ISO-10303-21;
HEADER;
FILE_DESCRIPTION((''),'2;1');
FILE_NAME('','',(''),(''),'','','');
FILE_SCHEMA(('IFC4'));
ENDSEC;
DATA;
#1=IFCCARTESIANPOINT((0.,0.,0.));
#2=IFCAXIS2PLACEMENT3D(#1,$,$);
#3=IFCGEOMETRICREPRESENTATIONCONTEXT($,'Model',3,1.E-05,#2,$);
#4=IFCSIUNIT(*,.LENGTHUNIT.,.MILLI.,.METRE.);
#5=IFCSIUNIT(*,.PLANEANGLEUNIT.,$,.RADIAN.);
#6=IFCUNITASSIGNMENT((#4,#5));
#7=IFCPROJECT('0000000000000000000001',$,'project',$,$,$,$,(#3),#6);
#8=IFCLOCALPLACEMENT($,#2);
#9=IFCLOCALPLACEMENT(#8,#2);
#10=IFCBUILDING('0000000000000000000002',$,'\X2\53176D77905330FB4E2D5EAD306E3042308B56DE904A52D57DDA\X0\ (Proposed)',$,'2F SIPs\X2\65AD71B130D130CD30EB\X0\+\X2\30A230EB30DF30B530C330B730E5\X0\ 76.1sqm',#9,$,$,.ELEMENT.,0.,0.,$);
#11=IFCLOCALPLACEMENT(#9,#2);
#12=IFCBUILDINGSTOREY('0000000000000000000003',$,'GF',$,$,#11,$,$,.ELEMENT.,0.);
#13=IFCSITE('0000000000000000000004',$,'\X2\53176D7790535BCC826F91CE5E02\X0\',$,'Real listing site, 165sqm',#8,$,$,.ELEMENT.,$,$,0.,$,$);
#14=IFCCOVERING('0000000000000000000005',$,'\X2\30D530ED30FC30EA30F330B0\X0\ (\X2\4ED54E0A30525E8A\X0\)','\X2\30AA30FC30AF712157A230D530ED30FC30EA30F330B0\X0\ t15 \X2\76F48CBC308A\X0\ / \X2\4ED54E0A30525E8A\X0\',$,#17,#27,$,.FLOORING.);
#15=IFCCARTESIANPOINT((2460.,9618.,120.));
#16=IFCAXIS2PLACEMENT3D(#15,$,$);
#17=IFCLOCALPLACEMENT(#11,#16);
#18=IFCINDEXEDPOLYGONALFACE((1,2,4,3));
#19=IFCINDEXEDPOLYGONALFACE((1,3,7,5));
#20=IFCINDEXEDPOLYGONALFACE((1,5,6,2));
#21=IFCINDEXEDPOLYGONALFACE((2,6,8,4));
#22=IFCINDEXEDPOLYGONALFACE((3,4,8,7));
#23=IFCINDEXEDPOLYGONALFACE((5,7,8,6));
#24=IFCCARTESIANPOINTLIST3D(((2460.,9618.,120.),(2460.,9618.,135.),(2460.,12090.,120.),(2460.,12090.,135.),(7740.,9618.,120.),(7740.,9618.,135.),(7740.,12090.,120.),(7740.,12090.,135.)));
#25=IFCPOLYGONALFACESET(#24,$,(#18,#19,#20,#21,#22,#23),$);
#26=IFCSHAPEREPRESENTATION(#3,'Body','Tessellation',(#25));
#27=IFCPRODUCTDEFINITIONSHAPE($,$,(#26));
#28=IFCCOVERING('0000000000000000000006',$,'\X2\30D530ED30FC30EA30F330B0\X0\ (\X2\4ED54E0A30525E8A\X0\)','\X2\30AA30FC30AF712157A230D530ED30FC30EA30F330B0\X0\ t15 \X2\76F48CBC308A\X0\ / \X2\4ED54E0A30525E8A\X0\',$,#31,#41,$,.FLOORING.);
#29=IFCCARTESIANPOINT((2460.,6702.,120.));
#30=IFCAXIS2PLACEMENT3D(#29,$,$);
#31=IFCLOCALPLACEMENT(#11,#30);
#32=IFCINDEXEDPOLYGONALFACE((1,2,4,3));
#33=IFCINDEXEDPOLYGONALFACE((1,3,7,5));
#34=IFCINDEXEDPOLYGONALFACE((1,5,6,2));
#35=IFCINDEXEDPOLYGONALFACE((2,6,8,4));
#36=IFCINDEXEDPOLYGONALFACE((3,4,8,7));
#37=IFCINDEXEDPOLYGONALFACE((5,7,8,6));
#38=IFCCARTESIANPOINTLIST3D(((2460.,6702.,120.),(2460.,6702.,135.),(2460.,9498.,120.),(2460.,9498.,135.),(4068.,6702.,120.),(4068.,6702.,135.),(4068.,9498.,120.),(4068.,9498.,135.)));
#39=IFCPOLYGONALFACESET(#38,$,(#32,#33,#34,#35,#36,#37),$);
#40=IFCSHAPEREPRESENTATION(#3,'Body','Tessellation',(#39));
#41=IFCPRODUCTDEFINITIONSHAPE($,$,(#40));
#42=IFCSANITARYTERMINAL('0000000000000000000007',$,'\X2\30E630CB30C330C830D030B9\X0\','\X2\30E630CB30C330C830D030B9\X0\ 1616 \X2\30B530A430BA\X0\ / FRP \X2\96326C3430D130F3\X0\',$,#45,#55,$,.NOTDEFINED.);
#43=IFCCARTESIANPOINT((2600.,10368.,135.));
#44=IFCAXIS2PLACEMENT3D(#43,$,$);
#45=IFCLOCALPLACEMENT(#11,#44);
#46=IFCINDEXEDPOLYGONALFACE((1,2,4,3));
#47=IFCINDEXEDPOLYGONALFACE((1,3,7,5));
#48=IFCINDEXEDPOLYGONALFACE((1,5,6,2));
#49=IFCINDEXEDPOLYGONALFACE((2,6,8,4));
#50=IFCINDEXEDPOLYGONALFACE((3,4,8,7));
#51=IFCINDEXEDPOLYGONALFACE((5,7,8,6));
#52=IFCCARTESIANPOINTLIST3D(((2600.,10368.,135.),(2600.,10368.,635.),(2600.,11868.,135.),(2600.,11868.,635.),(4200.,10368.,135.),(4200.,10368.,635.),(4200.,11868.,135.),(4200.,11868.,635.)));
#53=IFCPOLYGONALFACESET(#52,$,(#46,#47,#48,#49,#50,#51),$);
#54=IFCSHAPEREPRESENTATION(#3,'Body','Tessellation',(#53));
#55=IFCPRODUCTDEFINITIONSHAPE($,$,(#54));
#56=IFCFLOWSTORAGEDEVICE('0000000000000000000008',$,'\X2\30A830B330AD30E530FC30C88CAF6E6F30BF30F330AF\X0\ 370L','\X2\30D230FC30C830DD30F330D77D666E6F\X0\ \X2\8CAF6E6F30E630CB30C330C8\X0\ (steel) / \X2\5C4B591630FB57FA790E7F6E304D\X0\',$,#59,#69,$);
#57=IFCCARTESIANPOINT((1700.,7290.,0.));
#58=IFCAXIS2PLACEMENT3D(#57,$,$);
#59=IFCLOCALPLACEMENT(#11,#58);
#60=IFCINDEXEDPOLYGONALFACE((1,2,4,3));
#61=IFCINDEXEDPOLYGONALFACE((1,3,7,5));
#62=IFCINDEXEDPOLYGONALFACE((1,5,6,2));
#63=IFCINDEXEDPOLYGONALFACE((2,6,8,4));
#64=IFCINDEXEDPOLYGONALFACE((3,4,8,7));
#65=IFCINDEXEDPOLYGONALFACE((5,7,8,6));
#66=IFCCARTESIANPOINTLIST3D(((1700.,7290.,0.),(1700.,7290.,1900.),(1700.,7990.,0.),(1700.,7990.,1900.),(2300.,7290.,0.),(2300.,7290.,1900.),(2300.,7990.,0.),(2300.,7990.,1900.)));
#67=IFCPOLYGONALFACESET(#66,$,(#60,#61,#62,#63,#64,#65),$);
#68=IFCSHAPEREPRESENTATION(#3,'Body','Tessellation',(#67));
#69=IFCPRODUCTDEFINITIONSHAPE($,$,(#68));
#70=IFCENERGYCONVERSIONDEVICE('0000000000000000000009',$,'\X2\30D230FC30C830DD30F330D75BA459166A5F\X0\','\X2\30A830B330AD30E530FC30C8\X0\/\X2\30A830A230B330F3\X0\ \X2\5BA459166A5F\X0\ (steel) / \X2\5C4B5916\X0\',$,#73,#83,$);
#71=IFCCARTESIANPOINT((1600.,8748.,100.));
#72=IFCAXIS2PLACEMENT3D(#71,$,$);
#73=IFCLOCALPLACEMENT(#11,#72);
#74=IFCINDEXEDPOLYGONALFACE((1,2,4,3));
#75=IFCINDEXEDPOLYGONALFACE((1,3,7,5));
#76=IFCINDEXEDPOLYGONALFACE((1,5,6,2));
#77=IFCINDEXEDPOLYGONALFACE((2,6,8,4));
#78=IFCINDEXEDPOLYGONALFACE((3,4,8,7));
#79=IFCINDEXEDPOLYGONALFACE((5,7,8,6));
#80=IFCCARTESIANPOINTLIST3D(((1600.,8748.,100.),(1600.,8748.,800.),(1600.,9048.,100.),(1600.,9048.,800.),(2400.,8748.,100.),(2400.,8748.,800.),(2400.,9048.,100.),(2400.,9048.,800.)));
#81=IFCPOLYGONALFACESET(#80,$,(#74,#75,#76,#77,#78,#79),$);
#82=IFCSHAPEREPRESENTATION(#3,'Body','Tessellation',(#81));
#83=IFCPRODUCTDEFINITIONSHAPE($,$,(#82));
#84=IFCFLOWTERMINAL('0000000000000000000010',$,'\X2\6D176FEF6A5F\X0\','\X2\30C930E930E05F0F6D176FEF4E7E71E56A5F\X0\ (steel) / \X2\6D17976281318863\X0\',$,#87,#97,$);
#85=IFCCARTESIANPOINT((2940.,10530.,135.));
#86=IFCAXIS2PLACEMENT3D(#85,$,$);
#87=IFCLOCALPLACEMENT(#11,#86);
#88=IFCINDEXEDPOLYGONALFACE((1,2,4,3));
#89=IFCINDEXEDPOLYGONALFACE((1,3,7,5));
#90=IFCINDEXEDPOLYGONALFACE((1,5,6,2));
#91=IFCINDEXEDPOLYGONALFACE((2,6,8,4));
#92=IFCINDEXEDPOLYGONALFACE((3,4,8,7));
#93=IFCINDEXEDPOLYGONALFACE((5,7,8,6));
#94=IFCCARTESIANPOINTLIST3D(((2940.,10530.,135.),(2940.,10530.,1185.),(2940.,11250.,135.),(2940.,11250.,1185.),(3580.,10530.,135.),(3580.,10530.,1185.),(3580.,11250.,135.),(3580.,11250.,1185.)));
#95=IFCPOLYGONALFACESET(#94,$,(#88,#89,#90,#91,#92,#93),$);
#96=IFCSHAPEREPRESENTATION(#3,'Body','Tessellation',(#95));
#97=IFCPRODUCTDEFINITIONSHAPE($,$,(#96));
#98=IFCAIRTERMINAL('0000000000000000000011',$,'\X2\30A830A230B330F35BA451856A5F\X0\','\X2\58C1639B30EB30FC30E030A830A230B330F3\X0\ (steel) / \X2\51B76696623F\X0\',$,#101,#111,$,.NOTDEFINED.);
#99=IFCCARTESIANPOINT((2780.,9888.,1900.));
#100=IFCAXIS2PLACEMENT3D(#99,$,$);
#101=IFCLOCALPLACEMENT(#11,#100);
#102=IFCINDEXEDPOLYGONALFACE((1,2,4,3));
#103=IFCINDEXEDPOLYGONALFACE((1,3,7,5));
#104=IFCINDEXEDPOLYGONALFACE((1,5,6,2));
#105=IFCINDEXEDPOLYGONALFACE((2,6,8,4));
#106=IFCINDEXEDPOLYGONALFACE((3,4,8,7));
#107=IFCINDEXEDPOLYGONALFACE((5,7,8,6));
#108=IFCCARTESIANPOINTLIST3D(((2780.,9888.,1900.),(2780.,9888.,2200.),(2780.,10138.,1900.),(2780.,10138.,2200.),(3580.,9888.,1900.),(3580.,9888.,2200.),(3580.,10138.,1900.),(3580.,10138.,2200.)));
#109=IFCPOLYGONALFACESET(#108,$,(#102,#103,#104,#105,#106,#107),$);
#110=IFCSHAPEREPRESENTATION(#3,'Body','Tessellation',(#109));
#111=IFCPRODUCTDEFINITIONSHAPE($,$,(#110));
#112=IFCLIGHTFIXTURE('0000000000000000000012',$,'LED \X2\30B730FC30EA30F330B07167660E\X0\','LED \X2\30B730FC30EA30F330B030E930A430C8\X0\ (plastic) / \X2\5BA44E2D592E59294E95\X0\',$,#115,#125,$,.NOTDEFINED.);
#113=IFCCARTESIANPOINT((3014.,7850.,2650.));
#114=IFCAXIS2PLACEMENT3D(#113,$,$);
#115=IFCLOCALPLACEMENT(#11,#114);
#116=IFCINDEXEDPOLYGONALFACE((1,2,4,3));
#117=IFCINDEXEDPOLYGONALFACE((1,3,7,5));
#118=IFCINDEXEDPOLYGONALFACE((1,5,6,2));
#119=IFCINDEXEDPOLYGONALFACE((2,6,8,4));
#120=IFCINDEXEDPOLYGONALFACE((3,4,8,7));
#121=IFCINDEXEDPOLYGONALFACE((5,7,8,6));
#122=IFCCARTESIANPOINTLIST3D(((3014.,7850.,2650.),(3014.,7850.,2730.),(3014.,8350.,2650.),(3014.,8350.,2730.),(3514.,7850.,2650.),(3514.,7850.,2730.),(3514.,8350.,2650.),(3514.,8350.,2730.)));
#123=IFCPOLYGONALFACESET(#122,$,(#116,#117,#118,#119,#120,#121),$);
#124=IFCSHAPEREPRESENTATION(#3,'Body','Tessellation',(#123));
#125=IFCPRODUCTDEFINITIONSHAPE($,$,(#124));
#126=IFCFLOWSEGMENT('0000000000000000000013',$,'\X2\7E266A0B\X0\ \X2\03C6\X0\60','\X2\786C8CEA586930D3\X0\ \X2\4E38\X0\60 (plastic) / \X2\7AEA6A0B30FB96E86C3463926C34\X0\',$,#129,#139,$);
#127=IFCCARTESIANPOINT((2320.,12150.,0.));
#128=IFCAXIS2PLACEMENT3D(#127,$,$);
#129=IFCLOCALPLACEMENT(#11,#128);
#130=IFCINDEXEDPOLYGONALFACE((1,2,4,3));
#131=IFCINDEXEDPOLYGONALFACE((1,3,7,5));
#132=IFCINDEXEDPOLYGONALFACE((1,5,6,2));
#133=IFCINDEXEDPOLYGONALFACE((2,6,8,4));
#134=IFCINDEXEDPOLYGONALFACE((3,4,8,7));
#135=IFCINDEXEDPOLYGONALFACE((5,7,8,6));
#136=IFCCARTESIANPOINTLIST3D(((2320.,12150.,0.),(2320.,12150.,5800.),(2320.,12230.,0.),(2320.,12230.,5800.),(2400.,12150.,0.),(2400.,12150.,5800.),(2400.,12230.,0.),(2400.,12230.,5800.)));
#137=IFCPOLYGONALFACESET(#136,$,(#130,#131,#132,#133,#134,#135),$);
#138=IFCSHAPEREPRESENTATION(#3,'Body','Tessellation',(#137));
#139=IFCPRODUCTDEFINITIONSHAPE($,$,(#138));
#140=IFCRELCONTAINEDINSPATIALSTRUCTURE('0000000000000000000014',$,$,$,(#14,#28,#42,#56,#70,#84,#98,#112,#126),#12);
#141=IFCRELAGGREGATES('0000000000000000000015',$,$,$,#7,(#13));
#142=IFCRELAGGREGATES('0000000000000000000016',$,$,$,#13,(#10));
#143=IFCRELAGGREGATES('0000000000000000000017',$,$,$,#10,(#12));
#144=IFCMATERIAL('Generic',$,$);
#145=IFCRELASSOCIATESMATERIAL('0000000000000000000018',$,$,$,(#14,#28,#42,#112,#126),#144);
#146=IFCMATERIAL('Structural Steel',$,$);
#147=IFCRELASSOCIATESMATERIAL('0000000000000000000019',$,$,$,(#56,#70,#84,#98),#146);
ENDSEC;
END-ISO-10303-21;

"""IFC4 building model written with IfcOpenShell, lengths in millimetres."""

from ifc_helpers import new_model, si_unit, frame, frame_2d, origin, place, context, project, spatial, rectangle, extrude, material, element, save


model = new_model("IFC4")

# Units and contexts
model_context = context("Model", 3, precision=1e-05, world=origin())
ifc_project = project(units=[si_unit("LENGTHUNIT", "METRE", prefix="MILLI"), si_unit("PLANEANGLEUNIT", "RADIAN")], contexts=[model_context])

# Site, building, storey
site_placement = place(None, origin())
site = spatial("IfcSite", under=ifc_project, at=site_placement, Name="北海道富良野市", ObjectType="Real listing site, 165sqm", CompositionType="ELEMENT", RefElevation=0.0)
building_placement = place(site_placement, origin())
building = spatial("IfcBuilding", under=site, at=building_placement, Name="北海道・中庭のある回遊動線 (Proposed)", ObjectType="2F SIPs断熱パネル+アルミサッシュ 76.1sqm", CompositionType="ELEMENT", ElevationOfRefHeight=0.0, ElevationOfTerrain=0.0)
storey_placement = place(building_placement, origin())
storey = spatial("IfcBuildingStorey", under=building, at=storey_placement, Name="GF", CompositionType="ELEMENT", Elevation=0.0)

# Coverings
ifc_material_1 = material(Name="Generic")
covering_1_placement = place(storey_placement, frame((2460.0, 9618.0, 120.0)))
element("IfcCovering", 1, at=covering_1_placement, inside=storey, material=ifc_material_1, Name="フローリング (仕上げ床)", Description="オーク無垢フローリング t15 直貼り / 仕上げ床", PredefinedType="FLOORING", context=model_context, shape_type="SweptSolid", body=[
    extrude(rectangle(XDim=5280.0, YDim=2472.0, at=frame_2d((2640.0, 1236.0))), frame((2460.0, 9618.0, 120.0)), (0.0, 0.0, 1.0), 15.0),
])
covering_2_placement = place(storey_placement, frame((2460.0, 6702.0, 120.0)))
element("IfcCovering", 2, at=covering_2_placement, inside=storey, material=ifc_material_1, Name="フローリング (仕上げ床)", Description="オーク無垢フローリング t15 直貼り / 仕上げ床", PredefinedType="FLOORING", context=model_context, shape_type="SweptSolid", body=[
    extrude(rectangle(XDim=1608.0, YDim=2796.0, at=frame_2d((804.0, 1398.0))), frame((2460.0, 6702.0, 120.0)), (0.0, 0.0, 1.0), 15.0),
])

# Sanitary terminal
sanitary_terminal_placement = place(storey_placement, frame((2600.0, 10368.0, 135.0)))
element("IfcSanitaryTerminal", 3, at=sanitary_terminal_placement, inside=storey, material=ifc_material_1, Name="ユニットバス", Description="ユニットバス 1616 サイズ / FRP 防水パン", PredefinedType="NOTDEFINED", context=model_context, shape_type="SweptSolid", body=[
    extrude(rectangle(XDim=1600.0, YDim=1500.0, at=frame_2d((800.0, 750.0))), frame((2600.0, 10368.0, 135.0)), (0.0, 0.0, 1.0), 500.0),
])

# Flow storage device
ifc_material_2 = material(Name="Structural Steel")
flow_storage_device_placement = place(storey_placement, frame((1700.0, 7290.0, 0.0)))
element("IfcFlowStorageDevice", 4, at=flow_storage_device_placement, inside=storey, material=ifc_material_2, Name="エコキュート貯湯タンク 370L", Description="ヒートポンプ給湯 貯湯ユニット (steel) / 屋外・基礎置き", context=model_context, shape_type="SweptSolid", body=[
    extrude(rectangle(XDim=600.0, YDim=700.0, at=frame_2d((300.0, 350.0))), frame((1700.0, 7290.0, 0.0)), (0.0, 0.0, 1.0), 1900.0),
])

# Energy conversion device
energy_conversion_device_placement = place(storey_placement, frame((1600.0, 8748.0, 100.0)))
element("IfcEnergyConversionDevice", 5, at=energy_conversion_device_placement, inside=storey, material=ifc_material_2, Name="ヒートポンプ室外機", Description="エコキュート/エアコン 室外機 (steel) / 屋外", context=model_context, shape_type="SweptSolid", body=[
    extrude(rectangle(XDim=800.0, YDim=300.0, at=frame_2d((400.0, 150.0))), frame((1600.0, 8748.0, 100.0)), (0.0, 0.0, 1.0), 700.0),
])

# Flow terminal
flow_terminal_placement = place(storey_placement, frame((2940.0, 10530.0, 135.0)))
element("IfcFlowTerminal", 6, at=flow_terminal_placement, inside=storey, material=ifc_material_2, Name="洗濯機", Description="ドラム式洗濯乾燥機 (steel) / 洗面脱衣", context=model_context, shape_type="SweptSolid", body=[
    extrude(rectangle(XDim=640.0, YDim=720.0, at=frame_2d((320.0, 360.0))), frame((2940.0, 10530.0, 135.0)), (0.0, 0.0, 1.0), 1050.0),
])

# Air terminal
air_terminal_placement = place(storey_placement, frame((2780.0, 9888.0, 1900.0)))
element("IfcAirTerminal", 7, at=air_terminal_placement, inside=storey, material=ifc_material_2, Name="エアコン室内機", Description="壁掛ルームエアコン (steel) / 冷暖房", PredefinedType="NOTDEFINED", context=model_context, shape_type="SweptSolid", body=[
    extrude(rectangle(XDim=800.0, YDim=250.0, at=frame_2d((400.0, 125.0))), frame((2780.0, 9888.0, 1900.0)), (0.0, 0.0, 1.0), 300.0),
])

# Light fixture
light_fixture_placement = place(storey_placement, frame((3014.0, 7850.0, 2650.0)))
element("IfcLightFixture", 8, at=light_fixture_placement, inside=storey, material=ifc_material_1, Name="LED シーリング照明", Description="LED シーリングライト (plastic) / 室中央天井", PredefinedType="NOTDEFINED", context=model_context, shape_type="SweptSolid", body=[
    extrude(rectangle(XDim=500.0, YDim=500.0, at=frame_2d((250.0, 250.0))), frame((3014.0, 7850.0, 2650.0)), (0.0, 0.0, 1.0), 80.0),
])

# Flow segment
flow_segment_placement = place(storey_placement, frame((2320.0, 12150.0, 0.0)))
element("IfcFlowSegment", 9, at=flow_segment_placement, inside=storey, material=ifc_material_1, Name="縦樋 φ60", Description="硬質塩ビ 丸60 (plastic) / 竪樋・雨水排水", context=model_context, shape_type="SweptSolid", body=[
    extrude(rectangle(XDim=80.0, YDim=80.0, at=frame_2d((40.0, 40.0))), frame((2320.0, 12150.0, 0.0)), (0.0, 0.0, 1.0), 5800.0),
])

save(model, "model.ifc")
